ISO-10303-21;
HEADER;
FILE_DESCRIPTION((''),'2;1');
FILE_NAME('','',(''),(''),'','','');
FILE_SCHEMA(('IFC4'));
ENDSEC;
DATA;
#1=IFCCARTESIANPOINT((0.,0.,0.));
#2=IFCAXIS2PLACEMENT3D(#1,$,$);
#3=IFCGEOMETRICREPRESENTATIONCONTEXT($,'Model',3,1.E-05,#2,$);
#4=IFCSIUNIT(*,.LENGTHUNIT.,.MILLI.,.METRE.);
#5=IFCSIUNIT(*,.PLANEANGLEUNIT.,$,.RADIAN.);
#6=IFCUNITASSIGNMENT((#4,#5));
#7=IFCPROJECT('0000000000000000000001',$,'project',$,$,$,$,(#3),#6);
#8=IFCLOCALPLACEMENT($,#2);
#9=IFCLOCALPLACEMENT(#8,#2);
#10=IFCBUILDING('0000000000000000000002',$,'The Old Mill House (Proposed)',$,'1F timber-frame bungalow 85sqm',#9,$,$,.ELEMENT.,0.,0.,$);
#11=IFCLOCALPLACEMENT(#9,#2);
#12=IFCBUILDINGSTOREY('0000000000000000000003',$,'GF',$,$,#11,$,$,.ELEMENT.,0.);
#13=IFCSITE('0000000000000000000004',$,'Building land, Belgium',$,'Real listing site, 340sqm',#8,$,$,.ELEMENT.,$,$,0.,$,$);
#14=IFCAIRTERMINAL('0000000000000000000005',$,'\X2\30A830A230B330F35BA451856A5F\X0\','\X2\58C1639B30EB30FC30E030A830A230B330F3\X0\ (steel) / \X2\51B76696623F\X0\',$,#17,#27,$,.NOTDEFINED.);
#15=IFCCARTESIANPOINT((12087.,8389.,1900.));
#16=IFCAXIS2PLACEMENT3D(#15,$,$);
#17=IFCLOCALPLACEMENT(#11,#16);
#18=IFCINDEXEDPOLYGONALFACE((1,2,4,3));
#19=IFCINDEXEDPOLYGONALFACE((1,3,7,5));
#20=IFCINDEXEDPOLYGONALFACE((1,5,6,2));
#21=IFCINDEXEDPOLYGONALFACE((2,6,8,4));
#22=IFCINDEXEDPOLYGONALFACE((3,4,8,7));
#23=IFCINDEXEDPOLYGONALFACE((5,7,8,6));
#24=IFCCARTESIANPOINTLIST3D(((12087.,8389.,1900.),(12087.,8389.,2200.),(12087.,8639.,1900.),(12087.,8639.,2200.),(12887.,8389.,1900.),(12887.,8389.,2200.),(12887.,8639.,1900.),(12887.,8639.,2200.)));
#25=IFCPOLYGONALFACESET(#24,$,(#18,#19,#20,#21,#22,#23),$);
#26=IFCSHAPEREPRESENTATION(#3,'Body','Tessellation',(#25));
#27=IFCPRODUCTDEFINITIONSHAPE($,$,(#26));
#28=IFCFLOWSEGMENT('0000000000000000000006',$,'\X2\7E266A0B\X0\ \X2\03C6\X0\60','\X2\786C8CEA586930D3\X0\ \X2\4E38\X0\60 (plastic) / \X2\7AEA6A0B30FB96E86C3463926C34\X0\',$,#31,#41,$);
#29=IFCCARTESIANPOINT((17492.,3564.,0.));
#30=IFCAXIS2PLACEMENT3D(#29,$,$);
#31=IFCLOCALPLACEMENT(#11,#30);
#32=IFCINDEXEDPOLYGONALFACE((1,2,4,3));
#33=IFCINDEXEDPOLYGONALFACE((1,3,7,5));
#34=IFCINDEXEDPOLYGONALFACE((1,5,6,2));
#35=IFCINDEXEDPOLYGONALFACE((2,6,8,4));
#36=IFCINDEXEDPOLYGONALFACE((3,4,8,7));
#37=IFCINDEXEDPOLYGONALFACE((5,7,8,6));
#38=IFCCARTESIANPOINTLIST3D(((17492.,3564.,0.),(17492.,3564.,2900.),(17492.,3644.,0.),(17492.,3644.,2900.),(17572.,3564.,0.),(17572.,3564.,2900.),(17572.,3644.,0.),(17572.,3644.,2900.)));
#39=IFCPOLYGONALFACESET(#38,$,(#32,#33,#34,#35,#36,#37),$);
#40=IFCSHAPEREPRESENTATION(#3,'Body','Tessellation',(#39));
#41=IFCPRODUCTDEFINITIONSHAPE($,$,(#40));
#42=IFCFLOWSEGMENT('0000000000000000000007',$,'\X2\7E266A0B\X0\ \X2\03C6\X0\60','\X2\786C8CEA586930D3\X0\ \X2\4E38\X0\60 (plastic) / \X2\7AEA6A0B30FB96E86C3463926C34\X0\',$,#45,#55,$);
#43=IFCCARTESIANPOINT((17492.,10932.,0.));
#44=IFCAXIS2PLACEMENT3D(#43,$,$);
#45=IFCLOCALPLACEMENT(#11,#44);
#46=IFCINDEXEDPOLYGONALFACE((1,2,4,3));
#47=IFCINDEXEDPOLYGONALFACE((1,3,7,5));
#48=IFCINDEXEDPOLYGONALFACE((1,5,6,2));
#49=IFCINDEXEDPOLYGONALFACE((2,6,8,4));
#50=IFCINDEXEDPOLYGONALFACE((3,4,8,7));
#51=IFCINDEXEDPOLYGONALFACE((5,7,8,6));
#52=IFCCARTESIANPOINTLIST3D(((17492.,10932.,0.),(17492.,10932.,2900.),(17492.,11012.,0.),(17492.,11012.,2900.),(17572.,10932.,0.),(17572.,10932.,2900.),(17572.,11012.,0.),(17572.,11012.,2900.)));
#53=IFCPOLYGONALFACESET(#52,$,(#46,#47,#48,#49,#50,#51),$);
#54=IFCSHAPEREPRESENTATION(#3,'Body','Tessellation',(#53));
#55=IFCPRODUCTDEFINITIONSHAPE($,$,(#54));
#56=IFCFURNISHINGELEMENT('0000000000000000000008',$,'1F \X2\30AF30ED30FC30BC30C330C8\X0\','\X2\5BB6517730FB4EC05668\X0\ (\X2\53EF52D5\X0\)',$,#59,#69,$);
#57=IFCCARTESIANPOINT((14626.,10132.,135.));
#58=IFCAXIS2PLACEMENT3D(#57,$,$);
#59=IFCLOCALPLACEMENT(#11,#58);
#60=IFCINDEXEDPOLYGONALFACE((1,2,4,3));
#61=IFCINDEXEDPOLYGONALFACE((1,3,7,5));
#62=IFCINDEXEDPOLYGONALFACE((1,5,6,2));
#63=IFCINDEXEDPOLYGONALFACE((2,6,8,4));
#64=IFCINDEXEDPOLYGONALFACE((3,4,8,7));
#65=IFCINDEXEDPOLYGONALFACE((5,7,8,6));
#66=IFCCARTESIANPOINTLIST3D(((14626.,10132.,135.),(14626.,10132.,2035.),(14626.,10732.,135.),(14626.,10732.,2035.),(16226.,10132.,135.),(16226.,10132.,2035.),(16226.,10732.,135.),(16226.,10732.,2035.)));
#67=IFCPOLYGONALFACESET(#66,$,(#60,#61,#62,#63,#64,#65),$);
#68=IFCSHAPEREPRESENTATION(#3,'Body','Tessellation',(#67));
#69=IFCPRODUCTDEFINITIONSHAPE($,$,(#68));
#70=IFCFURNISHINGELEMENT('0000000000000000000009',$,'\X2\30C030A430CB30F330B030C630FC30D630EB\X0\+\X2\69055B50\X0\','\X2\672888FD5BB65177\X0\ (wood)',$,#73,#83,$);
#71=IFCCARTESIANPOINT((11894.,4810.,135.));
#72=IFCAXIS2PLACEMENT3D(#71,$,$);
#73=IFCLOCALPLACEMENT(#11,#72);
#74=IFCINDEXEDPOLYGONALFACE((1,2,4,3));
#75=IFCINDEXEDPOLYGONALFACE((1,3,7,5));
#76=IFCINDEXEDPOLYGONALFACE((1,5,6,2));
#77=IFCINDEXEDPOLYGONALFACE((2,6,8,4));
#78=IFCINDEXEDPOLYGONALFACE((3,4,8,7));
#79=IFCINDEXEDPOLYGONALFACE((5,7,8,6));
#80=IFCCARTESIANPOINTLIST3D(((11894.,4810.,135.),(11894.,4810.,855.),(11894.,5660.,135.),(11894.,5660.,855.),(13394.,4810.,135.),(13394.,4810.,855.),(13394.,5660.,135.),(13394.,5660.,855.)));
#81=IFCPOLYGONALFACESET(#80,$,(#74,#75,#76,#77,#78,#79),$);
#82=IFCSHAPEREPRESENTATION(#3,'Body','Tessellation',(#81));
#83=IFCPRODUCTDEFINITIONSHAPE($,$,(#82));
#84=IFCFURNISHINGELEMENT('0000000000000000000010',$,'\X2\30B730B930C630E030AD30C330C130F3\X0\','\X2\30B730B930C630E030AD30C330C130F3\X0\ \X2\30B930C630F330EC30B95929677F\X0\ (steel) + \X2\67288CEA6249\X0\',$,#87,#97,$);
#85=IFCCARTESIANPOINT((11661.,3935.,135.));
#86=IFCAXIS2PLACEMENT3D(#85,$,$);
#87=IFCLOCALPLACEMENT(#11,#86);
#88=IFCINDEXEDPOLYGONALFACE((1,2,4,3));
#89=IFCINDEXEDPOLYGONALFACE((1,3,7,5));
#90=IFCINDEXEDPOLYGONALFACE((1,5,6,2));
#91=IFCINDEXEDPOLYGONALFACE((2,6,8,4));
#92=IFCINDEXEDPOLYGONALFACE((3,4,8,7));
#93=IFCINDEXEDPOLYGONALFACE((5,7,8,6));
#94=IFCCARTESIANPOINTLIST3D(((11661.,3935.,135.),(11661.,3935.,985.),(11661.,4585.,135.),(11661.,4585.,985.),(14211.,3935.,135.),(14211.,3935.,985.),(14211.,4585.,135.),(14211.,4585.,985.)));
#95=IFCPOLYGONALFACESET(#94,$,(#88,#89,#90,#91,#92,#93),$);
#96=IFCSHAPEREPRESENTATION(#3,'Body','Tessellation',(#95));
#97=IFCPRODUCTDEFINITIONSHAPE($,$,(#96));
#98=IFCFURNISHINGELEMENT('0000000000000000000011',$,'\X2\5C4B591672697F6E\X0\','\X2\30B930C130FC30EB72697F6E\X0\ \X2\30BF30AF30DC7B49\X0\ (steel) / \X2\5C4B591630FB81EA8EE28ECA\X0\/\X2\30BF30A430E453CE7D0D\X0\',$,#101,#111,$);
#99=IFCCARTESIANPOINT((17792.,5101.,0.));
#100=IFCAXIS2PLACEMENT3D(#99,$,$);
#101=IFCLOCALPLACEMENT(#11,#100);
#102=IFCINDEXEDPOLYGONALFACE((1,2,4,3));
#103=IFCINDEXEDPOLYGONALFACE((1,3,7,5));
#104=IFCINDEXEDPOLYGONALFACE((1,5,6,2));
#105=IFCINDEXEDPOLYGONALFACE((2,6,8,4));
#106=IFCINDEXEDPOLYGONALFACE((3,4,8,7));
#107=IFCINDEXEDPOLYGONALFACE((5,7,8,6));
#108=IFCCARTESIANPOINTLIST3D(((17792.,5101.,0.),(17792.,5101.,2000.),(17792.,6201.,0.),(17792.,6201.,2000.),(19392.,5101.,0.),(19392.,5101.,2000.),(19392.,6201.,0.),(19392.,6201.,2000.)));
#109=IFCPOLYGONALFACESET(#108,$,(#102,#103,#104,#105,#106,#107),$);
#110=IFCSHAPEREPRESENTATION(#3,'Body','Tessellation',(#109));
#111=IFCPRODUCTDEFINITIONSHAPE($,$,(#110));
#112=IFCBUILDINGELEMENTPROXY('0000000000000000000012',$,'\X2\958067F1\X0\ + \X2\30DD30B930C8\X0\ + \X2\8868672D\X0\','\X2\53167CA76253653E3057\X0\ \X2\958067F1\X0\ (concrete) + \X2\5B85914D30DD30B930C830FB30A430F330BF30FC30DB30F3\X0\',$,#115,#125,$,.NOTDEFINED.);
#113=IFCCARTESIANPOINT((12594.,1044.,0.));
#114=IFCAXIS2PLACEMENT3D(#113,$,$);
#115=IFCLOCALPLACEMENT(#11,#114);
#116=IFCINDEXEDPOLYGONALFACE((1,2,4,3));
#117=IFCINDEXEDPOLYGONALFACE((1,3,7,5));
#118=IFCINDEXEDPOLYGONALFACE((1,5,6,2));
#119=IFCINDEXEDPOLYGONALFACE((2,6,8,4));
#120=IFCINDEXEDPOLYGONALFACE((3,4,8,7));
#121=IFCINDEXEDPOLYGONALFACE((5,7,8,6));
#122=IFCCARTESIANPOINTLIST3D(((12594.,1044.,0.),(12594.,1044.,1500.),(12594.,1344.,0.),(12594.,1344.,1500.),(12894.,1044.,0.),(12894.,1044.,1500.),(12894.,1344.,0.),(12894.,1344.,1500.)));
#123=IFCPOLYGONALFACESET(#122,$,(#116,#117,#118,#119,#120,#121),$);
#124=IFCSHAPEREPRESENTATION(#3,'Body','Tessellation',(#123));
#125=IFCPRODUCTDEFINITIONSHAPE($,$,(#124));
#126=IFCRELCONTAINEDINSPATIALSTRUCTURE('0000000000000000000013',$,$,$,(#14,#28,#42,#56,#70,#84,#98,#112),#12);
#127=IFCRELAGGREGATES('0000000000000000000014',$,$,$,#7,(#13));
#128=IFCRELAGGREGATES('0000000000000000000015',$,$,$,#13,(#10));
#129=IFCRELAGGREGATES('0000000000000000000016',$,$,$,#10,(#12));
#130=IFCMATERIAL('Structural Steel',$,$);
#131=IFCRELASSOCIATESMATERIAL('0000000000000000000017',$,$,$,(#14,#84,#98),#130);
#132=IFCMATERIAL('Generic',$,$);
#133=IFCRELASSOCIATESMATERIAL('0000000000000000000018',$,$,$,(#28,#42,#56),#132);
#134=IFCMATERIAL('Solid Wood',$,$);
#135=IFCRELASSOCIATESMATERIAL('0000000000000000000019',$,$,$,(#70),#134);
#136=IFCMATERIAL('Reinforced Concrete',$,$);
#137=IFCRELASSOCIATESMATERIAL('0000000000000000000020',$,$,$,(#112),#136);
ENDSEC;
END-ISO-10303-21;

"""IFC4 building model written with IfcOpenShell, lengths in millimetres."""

from ifc_helpers import new_model, si_unit, frame, frame_2d, origin, place, context, project, spatial, rectangle, extrude, material, element, save


model = new_model("IFC4")

# Units and contexts
model_context = context("Model", 3, precision=1e-05, world=origin())
ifc_project = project(units=[si_unit("LENGTHUNIT", "METRE", prefix="MILLI"), si_unit("PLANEANGLEUNIT", "RADIAN")], contexts=[model_context])

# Site, building, storey
site_placement = place(None, origin())
site = spatial("IfcSite", under=ifc_project, at=site_placement, Name="Building land, Belgium", ObjectType="Real listing site, 340sqm", CompositionType="ELEMENT", RefElevation=0.0)
building_placement = place(site_placement, origin())
building = spatial("IfcBuilding", under=site, at=building_placement, Name="The Old Mill House (Proposed)", ObjectType="1F timber-frame bungalow 85sqm", CompositionType="ELEMENT", ElevationOfRefHeight=0.0, ElevationOfTerrain=0.0)
storey_placement = place(building_placement, origin())
storey = spatial("IfcBuildingStorey", under=building, at=storey_placement, Name="GF", CompositionType="ELEMENT", Elevation=0.0)

# Shared definitions
ifc_material_1 = material(Name="Solid Wood")

# Shared definitions
ifc_material_2 = material(Name="Reinforced Concrete")

# Shared definitions
ifc_material_3 = material(Name="Generic")

# Shared definitions
ifc_material_4 = material(Name="Structural Steel")

# Air terminal
air_terminal_placement = place(storey_placement, frame((12087.0, 8389.0, 1900.0)))
element("IfcAirTerminal", 1, at=air_terminal_placement, inside=storey, material=ifc_material_4, Name="エアコン室内機", Description="壁掛ルームエアコン (steel) / 冷暖房", PredefinedType="NOTDEFINED", context=model_context, shape_type="SweptSolid", body=[
    extrude(rectangle(XDim=800.0, YDim=250.0, at=frame_2d((400.0, 125.0))), frame((12087.0, 8389.0, 1900.0)), (0.0, 0.0, 1.0), 300.0),
])

# Flow segments
flow_segment_1_placement = place(storey_placement, frame((17492.0, 3564.0, 0.0)))
element("IfcFlowSegment", 2, at=flow_segment_1_placement, inside=storey, material=ifc_material_3, Name="縦樋 φ60", Description="硬質塩ビ 丸60 (plastic) / 竪樋・雨水排水", context=model_context, shape_type="SweptSolid", body=[
    extrude(rectangle(XDim=80.0, YDim=80.0, at=frame_2d((40.0, 40.0))), frame((17492.0, 3564.0, 0.0)), (0.0, 0.0, 1.0), 2900.0),
])
flow_segment_2_placement = place(storey_placement, frame((17492.0, 10932.0, 0.0)))
element("IfcFlowSegment", 3, at=flow_segment_2_placement, inside=storey, material=ifc_material_3, Name="縦樋 φ60", Description="硬質塩ビ 丸60 (plastic) / 竪樋・雨水排水", context=model_context, shape_type="SweptSolid", body=[
    extrude(rectangle(XDim=80.0, YDim=80.0, at=frame_2d((40.0, 40.0))), frame((17492.0, 10932.0, 0.0)), (0.0, 0.0, 1.0), 2900.0),
])

# Furnishing elements
furnishing_1_placement = place(storey_placement, frame((14626.0, 10132.0, 135.0)))
element("IfcFurnishingElement", 4, at=furnishing_1_placement, inside=storey, material=ifc_material_3, Name="1F クローゼット", Description="家具・什器 (可動)", context=model_context, shape_type="SweptSolid", body=[
    extrude(rectangle(XDim=1600.0, YDim=600.0, at=frame_2d((800.0, 300.0))), frame((14626.0, 10132.0, 135.0)), (0.0, 0.0, 1.0), 1900.0),
])
furnishing_2_placement = place(storey_placement, frame((11894.0, 4810.0, 135.0)))
element("IfcFurnishingElement", 5, at=furnishing_2_placement, inside=storey, material=ifc_material_1, Name="ダイニングテーブル+椅子", Description="木製家具 (wood)", context=model_context, shape_type="SweptSolid", body=[
    extrude(rectangle(XDim=1500.0, YDim=850.0, at=frame_2d((750.0, 425.0))), frame((11894.0, 4810.0, 135.0)), (0.0, 0.0, 1.0), 720.0),
])
furnishing_3_placement = place(storey_placement, frame((11661.0, 3935.0, 135.0)))
element("IfcFurnishingElement", 6, at=furnishing_3_placement, inside=storey, material=ifc_material_4, Name="システムキッチン", Description="システムキッチン ステンレス天板 (steel) + 木質扉", context=model_context, shape_type="SweptSolid", body=[
    extrude(rectangle(XDim=2550.0, YDim=650.0, at=frame_2d((1275.0, 325.0))), frame((11661.0, 3935.0, 135.0)), (0.0, 0.0, 1.0), 850.0),
])
furnishing_4_placement = place(storey_placement, frame((17792.0, 5101.0, 0.0)))
element("IfcFurnishingElement", 7, at=furnishing_4_placement, inside=storey, material=ifc_material_4, Name="屋外物置", Description="スチール物置 タクボ等 (steel) / 屋外・自転車/タイヤ収納", context=model_context, shape_type="SweptSolid", body=[
    extrude(rectangle(XDim=1600.0, YDim=1100.0, at=frame_2d((800.0, 550.0))), frame((17792.0, 5101.0, 0.0)), (0.0, 0.0, 1.0), 2000.0),
])

# Building element proxy
proxy_placement = place(storey_placement, frame((12594.0, 1044.0, 0.0)))
element("IfcBuildingElementProxy", 8, at=proxy_placement, inside=storey, material=ifc_material_2, Name="門柱 + ポスト + 表札", Description="化粧打放し 門柱 (concrete) + 宅配ポスト・インターホン", PredefinedType="NOTDEFINED", context=model_context, shape_type="SweptSolid", body=[
    extrude(rectangle(XDim=300.0, YDim=300.0, at=frame_2d((150.0, 150.0))), frame((12594.0, 1044.0, 0.0)), (0.0, 0.0, 1.0), 1500.0),
])

save(model, "model.ifc")
